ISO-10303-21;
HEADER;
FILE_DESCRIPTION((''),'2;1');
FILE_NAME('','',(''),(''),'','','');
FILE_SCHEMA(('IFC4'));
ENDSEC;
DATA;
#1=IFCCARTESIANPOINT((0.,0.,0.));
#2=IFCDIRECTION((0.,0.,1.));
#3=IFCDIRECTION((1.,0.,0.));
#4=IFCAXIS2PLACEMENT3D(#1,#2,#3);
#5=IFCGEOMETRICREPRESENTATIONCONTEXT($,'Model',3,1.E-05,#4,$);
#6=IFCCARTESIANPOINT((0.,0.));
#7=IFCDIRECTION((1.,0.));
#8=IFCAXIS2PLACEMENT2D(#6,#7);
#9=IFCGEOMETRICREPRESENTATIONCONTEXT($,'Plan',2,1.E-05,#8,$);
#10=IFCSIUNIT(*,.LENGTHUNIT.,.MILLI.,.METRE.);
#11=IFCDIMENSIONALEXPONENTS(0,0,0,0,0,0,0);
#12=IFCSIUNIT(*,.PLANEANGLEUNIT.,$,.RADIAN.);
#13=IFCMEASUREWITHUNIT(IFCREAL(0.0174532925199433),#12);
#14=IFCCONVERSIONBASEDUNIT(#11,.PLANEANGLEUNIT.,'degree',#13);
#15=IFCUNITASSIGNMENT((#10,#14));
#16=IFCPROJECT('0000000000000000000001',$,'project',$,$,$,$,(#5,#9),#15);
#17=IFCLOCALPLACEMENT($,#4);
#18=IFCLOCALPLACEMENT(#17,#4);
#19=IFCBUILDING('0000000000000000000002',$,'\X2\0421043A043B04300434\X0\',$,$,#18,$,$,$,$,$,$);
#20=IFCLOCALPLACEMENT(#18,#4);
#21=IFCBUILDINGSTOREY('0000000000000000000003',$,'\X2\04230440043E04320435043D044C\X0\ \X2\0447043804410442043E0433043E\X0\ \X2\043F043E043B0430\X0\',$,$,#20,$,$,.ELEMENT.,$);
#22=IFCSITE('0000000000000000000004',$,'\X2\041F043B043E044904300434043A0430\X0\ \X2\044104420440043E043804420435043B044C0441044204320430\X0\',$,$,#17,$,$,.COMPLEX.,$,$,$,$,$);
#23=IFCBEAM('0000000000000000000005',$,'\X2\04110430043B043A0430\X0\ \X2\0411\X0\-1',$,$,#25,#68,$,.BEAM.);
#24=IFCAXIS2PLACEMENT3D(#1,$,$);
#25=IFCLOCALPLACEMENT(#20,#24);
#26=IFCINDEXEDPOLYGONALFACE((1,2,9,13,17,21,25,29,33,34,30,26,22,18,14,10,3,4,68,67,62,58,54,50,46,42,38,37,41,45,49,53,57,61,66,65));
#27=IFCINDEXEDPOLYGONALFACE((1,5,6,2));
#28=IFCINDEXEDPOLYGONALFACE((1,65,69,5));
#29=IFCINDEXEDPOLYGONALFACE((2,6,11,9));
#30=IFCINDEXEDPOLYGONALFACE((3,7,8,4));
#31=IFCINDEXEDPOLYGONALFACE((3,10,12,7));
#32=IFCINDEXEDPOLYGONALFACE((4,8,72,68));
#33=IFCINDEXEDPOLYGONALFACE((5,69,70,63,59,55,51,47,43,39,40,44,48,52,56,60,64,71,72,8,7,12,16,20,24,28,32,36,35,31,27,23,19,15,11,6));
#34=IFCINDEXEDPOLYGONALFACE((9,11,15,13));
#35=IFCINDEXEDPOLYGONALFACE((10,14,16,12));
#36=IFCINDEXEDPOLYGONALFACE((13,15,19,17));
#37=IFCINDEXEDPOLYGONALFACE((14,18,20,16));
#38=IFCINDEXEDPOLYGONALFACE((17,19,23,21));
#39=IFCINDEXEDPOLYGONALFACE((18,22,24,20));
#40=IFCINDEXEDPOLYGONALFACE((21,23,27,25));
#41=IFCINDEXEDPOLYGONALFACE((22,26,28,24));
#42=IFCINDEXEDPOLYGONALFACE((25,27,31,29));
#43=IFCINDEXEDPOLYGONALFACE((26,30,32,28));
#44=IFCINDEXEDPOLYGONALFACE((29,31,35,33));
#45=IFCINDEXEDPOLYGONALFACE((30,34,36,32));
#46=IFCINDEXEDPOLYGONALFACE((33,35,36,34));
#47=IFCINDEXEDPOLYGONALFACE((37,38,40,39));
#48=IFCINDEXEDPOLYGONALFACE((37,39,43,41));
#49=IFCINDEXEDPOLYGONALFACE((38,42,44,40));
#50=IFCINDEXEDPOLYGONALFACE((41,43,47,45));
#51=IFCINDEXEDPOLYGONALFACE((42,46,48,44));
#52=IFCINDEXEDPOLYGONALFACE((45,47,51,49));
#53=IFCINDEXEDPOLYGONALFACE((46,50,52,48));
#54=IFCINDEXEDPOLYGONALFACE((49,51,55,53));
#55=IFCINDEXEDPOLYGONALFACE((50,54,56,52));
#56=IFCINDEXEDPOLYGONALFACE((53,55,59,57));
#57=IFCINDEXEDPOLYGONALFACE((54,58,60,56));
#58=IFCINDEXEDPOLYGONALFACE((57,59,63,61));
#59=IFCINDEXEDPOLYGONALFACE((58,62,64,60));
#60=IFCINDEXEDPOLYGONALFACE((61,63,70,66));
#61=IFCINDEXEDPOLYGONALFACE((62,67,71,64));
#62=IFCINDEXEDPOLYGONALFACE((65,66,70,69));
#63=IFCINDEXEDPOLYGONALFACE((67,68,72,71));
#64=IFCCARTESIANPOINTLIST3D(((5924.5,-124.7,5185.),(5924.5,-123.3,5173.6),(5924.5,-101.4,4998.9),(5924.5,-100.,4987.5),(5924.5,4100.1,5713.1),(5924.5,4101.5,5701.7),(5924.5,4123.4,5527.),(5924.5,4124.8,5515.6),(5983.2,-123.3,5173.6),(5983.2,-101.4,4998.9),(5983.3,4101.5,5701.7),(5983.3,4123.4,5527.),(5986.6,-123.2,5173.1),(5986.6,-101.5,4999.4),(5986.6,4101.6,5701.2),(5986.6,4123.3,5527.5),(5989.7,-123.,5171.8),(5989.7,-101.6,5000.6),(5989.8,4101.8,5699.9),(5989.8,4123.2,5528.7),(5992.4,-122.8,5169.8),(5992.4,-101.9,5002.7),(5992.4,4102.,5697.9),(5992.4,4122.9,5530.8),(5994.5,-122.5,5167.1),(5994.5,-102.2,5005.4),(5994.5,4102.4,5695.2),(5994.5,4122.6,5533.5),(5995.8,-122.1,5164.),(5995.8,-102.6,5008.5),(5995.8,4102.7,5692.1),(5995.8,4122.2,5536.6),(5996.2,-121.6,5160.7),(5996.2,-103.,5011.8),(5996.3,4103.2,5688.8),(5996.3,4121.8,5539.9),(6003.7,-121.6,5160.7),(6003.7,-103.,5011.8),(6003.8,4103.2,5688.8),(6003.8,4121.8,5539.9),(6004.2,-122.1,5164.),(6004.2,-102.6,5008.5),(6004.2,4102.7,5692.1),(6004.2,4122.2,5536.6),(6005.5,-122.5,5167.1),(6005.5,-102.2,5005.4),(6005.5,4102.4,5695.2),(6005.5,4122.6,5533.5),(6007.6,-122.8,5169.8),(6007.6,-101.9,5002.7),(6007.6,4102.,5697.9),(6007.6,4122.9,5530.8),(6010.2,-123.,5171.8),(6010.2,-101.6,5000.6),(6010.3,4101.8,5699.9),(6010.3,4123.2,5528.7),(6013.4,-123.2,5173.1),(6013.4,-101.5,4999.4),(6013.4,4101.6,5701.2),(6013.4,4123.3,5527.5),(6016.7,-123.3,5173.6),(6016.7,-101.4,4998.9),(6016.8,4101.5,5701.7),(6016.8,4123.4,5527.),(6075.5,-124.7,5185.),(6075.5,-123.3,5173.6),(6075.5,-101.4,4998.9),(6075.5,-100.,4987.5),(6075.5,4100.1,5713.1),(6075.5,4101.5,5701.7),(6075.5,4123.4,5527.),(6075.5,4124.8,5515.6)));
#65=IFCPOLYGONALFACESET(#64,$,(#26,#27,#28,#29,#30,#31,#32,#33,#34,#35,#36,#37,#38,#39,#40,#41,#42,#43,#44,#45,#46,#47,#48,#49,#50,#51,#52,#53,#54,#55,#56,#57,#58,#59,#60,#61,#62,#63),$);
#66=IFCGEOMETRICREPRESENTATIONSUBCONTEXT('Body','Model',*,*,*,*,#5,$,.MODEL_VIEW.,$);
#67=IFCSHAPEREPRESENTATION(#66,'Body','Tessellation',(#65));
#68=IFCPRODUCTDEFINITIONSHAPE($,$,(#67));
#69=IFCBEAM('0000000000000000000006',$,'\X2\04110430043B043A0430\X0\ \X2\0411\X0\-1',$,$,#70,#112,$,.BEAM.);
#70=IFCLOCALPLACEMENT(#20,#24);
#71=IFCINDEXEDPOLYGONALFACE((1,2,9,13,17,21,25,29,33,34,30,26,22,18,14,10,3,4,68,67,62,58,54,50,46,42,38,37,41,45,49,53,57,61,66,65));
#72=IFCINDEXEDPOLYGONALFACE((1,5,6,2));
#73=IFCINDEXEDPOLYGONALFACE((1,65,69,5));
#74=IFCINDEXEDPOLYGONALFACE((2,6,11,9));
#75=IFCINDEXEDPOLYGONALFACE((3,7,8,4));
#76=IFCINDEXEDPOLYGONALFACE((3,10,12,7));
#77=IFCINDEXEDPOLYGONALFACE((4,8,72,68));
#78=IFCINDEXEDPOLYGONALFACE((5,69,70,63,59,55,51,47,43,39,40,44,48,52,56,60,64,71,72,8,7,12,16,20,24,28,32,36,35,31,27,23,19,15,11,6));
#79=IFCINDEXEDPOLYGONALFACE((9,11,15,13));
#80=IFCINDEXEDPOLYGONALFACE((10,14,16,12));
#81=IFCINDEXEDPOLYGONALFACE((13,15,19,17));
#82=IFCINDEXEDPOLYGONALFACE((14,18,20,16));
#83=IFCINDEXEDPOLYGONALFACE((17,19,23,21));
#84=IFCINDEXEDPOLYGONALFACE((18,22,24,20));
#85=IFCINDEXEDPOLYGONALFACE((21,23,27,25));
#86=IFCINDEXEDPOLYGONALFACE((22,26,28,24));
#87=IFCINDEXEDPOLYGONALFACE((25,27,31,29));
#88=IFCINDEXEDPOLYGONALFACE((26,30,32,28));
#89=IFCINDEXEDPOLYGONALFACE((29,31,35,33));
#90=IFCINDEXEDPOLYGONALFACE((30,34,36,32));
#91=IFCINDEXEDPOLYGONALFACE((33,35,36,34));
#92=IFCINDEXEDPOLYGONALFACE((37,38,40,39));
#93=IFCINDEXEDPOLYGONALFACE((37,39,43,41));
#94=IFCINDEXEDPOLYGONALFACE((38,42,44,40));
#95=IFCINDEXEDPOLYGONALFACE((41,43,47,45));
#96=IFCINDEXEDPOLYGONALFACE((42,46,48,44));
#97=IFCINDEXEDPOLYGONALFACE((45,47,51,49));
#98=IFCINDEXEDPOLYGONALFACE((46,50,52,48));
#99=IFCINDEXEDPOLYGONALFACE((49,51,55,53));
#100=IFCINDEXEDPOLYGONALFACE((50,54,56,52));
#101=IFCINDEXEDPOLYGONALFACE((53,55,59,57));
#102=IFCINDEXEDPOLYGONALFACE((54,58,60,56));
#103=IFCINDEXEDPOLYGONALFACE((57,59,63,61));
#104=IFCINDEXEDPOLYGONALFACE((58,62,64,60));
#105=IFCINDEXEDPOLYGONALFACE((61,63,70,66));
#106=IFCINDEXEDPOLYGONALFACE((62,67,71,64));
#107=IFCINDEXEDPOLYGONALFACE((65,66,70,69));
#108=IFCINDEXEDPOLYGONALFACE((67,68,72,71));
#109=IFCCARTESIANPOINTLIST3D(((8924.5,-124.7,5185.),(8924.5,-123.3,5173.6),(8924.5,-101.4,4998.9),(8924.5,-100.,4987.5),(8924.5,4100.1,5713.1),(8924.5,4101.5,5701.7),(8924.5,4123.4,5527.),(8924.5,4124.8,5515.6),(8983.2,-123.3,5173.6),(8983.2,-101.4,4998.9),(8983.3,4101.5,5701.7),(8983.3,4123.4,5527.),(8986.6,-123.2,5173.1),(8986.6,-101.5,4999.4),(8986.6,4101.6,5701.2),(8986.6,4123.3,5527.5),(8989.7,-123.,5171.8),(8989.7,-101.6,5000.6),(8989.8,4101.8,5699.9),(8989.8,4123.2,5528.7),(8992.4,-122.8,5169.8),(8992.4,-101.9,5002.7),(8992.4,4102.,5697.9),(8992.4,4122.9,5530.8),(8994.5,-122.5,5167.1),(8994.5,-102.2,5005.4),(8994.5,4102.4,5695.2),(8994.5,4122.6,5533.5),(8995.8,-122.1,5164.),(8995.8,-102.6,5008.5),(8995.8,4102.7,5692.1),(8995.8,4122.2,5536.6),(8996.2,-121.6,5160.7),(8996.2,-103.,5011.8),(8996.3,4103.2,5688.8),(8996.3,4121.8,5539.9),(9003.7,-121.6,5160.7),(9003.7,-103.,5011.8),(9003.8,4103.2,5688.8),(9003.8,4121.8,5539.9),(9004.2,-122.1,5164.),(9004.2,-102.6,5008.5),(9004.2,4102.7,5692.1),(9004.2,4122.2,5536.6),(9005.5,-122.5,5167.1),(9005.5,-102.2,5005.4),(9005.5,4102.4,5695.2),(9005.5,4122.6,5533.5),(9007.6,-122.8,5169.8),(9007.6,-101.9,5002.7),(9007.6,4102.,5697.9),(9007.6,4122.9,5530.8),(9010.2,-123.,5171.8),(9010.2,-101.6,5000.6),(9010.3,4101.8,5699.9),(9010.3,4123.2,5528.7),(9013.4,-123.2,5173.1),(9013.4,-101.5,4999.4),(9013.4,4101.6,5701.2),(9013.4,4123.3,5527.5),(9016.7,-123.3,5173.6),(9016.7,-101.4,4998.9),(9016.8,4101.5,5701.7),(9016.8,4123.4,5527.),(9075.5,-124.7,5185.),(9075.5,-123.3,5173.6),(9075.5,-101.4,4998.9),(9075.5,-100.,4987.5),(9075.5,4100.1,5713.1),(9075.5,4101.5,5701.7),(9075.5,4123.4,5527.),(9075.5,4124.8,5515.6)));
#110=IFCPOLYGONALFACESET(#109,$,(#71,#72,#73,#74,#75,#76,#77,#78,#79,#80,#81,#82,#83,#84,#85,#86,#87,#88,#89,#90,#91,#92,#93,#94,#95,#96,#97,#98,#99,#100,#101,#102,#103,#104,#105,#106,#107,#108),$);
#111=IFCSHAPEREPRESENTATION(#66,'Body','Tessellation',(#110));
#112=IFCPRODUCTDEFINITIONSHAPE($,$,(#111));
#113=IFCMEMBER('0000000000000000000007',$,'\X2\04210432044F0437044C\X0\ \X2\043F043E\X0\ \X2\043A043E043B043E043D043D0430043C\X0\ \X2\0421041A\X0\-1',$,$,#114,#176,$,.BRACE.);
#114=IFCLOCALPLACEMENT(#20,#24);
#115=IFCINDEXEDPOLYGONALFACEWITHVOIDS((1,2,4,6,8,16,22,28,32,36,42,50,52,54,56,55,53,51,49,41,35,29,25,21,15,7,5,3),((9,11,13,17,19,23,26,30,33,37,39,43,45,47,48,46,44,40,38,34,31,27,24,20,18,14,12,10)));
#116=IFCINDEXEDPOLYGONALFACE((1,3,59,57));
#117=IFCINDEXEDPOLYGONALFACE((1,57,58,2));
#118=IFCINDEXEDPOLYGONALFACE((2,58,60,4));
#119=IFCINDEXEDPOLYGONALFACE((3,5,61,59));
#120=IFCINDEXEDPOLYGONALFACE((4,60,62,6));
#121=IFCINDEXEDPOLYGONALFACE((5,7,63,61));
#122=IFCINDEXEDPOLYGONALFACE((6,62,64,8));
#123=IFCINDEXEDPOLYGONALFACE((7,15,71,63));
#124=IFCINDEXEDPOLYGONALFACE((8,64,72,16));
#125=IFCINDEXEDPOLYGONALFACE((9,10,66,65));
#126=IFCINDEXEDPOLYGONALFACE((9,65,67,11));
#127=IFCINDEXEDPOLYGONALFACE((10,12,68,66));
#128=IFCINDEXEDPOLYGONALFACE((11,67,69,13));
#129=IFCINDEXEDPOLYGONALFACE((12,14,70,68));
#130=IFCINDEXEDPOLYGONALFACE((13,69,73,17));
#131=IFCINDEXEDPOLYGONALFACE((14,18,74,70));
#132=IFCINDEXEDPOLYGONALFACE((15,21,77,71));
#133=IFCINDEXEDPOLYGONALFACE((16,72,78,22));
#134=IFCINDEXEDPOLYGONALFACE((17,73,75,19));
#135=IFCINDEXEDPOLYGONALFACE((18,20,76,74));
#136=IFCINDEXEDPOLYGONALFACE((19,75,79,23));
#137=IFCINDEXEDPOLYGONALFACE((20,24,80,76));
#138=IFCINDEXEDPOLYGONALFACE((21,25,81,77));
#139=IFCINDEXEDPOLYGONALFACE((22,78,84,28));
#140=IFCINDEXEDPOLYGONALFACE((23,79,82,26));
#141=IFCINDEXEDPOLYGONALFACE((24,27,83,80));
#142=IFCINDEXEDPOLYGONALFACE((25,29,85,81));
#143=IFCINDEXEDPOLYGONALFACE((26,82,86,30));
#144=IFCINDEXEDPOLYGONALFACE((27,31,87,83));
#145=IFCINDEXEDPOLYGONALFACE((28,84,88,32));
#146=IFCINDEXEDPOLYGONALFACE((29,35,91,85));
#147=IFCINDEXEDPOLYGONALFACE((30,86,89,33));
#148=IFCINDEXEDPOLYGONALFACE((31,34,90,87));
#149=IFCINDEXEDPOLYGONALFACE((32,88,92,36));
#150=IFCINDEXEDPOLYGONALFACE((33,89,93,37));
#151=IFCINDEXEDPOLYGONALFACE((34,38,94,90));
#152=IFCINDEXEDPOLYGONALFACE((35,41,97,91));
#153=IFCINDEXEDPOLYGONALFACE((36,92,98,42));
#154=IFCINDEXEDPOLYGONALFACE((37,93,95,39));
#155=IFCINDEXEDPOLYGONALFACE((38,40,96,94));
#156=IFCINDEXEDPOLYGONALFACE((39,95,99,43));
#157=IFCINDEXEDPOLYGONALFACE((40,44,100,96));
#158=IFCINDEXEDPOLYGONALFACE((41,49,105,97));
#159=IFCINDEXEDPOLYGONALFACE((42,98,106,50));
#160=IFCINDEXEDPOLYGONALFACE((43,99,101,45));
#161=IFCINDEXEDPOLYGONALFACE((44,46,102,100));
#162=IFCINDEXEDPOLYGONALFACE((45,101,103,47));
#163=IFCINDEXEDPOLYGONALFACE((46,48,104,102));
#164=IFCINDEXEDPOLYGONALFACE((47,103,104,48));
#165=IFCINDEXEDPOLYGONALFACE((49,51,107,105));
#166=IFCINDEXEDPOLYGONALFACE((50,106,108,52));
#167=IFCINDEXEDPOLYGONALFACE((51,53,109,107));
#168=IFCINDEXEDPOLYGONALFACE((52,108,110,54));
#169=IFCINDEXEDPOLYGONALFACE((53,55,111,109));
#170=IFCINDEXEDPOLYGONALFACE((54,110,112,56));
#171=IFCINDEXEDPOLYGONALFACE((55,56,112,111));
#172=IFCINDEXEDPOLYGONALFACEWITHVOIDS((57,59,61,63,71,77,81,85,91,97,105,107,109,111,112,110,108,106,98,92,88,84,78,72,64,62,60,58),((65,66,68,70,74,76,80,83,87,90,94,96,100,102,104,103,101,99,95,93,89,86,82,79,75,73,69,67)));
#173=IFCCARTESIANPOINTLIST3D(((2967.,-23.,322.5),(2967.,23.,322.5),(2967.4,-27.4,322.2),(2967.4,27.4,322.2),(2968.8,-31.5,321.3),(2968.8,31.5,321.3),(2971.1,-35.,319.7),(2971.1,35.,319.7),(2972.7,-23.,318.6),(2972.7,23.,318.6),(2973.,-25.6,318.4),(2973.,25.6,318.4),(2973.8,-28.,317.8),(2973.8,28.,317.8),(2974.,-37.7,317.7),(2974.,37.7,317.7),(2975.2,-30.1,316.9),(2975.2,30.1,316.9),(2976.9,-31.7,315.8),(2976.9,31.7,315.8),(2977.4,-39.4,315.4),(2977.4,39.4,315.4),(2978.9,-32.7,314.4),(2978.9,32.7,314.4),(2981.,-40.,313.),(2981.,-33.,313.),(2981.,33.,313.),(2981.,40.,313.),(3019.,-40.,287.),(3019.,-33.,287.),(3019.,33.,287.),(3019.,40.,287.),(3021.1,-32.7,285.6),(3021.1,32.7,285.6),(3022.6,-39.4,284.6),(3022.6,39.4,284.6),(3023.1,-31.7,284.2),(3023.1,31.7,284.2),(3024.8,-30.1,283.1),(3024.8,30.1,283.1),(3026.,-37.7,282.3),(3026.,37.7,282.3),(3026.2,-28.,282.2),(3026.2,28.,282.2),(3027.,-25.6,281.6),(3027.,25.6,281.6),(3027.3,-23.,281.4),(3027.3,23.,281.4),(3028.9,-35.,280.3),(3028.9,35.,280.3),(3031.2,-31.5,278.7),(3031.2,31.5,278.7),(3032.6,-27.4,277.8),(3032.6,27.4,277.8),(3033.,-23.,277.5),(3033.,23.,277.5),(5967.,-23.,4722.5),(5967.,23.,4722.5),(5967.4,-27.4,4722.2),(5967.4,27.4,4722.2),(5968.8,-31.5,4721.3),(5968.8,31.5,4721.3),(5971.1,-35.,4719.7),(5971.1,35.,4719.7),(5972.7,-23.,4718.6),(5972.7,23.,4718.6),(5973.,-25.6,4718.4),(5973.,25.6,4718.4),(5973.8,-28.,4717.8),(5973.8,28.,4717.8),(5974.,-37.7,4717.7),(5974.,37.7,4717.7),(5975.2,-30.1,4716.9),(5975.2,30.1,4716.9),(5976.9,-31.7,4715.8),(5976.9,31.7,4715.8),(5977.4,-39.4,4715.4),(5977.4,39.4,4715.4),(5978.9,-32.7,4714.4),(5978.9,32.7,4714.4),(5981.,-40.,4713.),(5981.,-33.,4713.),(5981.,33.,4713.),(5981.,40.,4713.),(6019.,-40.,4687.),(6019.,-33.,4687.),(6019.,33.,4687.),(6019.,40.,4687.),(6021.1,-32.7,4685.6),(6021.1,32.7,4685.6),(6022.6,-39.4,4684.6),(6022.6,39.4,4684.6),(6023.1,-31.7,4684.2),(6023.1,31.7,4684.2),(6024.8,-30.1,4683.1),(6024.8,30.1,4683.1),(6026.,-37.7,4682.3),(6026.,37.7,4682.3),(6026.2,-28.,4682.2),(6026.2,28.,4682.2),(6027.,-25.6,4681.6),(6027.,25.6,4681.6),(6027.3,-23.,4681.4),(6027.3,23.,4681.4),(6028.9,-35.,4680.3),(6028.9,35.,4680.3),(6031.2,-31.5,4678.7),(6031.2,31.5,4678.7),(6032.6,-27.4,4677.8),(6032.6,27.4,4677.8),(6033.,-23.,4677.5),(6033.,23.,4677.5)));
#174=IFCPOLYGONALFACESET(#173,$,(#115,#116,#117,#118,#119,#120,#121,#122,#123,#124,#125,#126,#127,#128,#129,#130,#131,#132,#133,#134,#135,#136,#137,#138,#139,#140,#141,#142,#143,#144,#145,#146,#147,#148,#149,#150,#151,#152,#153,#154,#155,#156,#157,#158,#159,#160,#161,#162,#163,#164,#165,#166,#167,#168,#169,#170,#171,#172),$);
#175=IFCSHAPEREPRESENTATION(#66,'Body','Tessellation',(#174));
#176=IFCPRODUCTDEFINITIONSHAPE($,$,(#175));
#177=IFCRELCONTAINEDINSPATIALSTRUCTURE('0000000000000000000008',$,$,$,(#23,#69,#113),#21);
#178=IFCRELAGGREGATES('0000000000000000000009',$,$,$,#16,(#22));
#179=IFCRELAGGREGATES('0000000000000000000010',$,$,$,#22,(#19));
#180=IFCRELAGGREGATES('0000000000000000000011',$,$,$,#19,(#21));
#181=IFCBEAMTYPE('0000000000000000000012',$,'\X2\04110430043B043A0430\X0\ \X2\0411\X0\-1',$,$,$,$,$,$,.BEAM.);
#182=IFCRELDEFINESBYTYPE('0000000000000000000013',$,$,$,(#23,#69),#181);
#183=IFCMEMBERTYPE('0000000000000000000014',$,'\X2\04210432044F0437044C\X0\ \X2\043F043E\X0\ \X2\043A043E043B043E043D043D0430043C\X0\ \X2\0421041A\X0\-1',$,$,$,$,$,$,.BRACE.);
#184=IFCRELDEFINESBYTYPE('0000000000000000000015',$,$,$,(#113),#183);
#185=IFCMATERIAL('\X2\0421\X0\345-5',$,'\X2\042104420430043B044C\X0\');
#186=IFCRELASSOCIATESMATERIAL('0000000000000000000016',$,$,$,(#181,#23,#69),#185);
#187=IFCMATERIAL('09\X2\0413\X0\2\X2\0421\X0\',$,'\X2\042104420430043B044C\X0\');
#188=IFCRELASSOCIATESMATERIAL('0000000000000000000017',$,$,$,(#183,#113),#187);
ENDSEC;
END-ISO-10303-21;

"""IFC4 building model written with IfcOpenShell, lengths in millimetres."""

from ifc_helpers import new_model, entity, si_unit, converted_unit, frame, origin_with_axes, origin_2d_with_axis, place, context, subcontext, project, spatial, hollow_rectangle, i_section, extrude, material, material_profile, profile_set, profile_usage, type_object, element, save


model = new_model("IFC4")

# Units and contexts
model_context = context("Model", 3, precision=1e-05, world=origin_with_axes())
plan_context = context("Plan", 2, precision=1e-05, world=origin_2d_with_axis())
body_context = subcontext(model_context, "Body", "Model", "MODEL_VIEW")
ifc_project = project(units=[si_unit("LENGTHUNIT", "METRE", prefix="MILLI"), converted_unit("PLANEANGLEUNIT", "degree", entity("IfcReal", 0.0174532925199433), si_unit("PLANEANGLEUNIT", "RADIAN"), dimensions=[0, 0, 0, 0, 0, 0, 0])], contexts=[model_context, plan_context])

# Site, building, storey
site_placement = place(None, origin_with_axes())
site = spatial("IfcSite", under=ifc_project, at=site_placement, Name="Площадка строительства", CompositionType="COMPLEX")
building_placement = place(site_placement, origin_with_axes())
building = spatial("IfcBuilding", under=site, at=building_placement, Name="Склад")
storey_placement = place(building_placement, origin_with_axes())
storey = spatial("IfcBuildingStorey", under=building, at=storey_placement, Name="Уровень чистого пола", CompositionType="ELEMENT")

# Shared definitions
ifc_material_1 = material(Name="С345-5", Category="Сталь")

# Beams
ifc_material_profile_1 = material_profile(ifc_material_1, i_section(OverallWidth=151.0, OverallDepth=199.0, WebThickness=7.5, FlangeThickness=11.5, FilletRadius=13.0, FlangeEdgeRadius=0.0, FlangeSlope=0.0))
ifc_profile_set_1 = profile_set([ifc_material_profile_1], Name="I20H2_S345-5")
beam_type_1 = type_object("IfcBeamType", Name="Балка Б-1", PredefinedType="BEAM", material=ifc_profile_set_1)
ifc_profile_usage_1 = profile_usage(ifc_profile_set_1, cardinal=2)
beam_1_placement = place(storey_placement, frame((6000.0, -100.0, 4987.5), z_axis=(0.0, 0.992278, 0.124035), x_axis=(-1.0, 0.0, 0.0)))
element("IfcBeam", 1, at=beam_1_placement, inside=storey, type_object=beam_type_1, material=ifc_profile_usage_1, Name="Балка Б-1", PredefinedType="BEAM", context=body_context, shape_type="SweptSolid", body=[
    extrude(i_section(OverallWidth=151.0, OverallDepth=199.0, WebThickness=7.5, FlangeThickness=11.5, FilletRadius=13.0, FlangeEdgeRadius=0.0, FlangeSlope=0.0), frame((0.0, 99.5, 0.0), z_axis=(0.0, 0.0, 1.0), x_axis=(1.0, 0.0, 0.0)), (0.0, 0.0, 1.0), 4257.7),
])
ifc_profile_usage_2 = profile_usage(ifc_profile_set_1, cardinal=2)
beam_2_placement = place(storey_placement, frame((9000.0, -100.0, 4987.5), z_axis=(0.0, 0.992278, 0.124035), x_axis=(-1.0, 0.0, 0.0)))
element("IfcBeam", 2, at=beam_2_placement, inside=storey, type_object=beam_type_1, material=ifc_profile_usage_2, Name="Балка Б-1", PredefinedType="BEAM", context=body_context, shape_type="SweptSolid", body=[
    extrude(i_section(OverallWidth=151.0, OverallDepth=199.0, WebThickness=7.5, FlangeThickness=11.5, FilletRadius=13.0, FlangeEdgeRadius=0.0, FlangeSlope=0.0), frame((0.0, 99.5, 0.0), z_axis=(0.0, 0.0, 1.0), x_axis=(1.0, 0.0, 0.0)), (0.0, 0.0, 1.0), 4257.7),
])

# Member
ifc_material_2 = material(Name="09Г2С", Category="Сталь")
ifc_material_profile_2 = material_profile(ifc_material_2, hollow_rectangle(XDim=80.0, YDim=80.0, WallThickness=7.0, InnerFilletRadius=10.0, OuterFilletRadius=17.0))
ifc_profile_set_2 = profile_set([ifc_material_profile_2], Name="PK80x7_09G2S")
ifc_profile_usage_3 = profile_usage(ifc_profile_set_2, cardinal=5)
member_type_1 = type_object("IfcMemberType", Name="Связь по колоннам СК-1", PredefinedType="BRACE", material=ifc_profile_set_2)
member_1_placement = place(storey_placement, frame((3000.0, 0.0, 300.0), z_axis=(0.563337, 0.0, 0.826227), x_axis=(0.0, 1.0, 0.0)))
element("IfcMember", 3, at=member_1_placement, inside=storey, type_object=member_type_1, material=ifc_profile_usage_3, Name="Связь по колоннам СК-1", PredefinedType="BRACE", context=body_context, shape_type="SweptSolid", body=[
    extrude(hollow_rectangle(XDim=80.0, YDim=80.0, WallThickness=7.0, InnerFilletRadius=10.0, OuterFilletRadius=17.0), origin_with_axes(), (0.0, 0.0, 1.0), 5325.4),
])

save(model, "model.ifc")
